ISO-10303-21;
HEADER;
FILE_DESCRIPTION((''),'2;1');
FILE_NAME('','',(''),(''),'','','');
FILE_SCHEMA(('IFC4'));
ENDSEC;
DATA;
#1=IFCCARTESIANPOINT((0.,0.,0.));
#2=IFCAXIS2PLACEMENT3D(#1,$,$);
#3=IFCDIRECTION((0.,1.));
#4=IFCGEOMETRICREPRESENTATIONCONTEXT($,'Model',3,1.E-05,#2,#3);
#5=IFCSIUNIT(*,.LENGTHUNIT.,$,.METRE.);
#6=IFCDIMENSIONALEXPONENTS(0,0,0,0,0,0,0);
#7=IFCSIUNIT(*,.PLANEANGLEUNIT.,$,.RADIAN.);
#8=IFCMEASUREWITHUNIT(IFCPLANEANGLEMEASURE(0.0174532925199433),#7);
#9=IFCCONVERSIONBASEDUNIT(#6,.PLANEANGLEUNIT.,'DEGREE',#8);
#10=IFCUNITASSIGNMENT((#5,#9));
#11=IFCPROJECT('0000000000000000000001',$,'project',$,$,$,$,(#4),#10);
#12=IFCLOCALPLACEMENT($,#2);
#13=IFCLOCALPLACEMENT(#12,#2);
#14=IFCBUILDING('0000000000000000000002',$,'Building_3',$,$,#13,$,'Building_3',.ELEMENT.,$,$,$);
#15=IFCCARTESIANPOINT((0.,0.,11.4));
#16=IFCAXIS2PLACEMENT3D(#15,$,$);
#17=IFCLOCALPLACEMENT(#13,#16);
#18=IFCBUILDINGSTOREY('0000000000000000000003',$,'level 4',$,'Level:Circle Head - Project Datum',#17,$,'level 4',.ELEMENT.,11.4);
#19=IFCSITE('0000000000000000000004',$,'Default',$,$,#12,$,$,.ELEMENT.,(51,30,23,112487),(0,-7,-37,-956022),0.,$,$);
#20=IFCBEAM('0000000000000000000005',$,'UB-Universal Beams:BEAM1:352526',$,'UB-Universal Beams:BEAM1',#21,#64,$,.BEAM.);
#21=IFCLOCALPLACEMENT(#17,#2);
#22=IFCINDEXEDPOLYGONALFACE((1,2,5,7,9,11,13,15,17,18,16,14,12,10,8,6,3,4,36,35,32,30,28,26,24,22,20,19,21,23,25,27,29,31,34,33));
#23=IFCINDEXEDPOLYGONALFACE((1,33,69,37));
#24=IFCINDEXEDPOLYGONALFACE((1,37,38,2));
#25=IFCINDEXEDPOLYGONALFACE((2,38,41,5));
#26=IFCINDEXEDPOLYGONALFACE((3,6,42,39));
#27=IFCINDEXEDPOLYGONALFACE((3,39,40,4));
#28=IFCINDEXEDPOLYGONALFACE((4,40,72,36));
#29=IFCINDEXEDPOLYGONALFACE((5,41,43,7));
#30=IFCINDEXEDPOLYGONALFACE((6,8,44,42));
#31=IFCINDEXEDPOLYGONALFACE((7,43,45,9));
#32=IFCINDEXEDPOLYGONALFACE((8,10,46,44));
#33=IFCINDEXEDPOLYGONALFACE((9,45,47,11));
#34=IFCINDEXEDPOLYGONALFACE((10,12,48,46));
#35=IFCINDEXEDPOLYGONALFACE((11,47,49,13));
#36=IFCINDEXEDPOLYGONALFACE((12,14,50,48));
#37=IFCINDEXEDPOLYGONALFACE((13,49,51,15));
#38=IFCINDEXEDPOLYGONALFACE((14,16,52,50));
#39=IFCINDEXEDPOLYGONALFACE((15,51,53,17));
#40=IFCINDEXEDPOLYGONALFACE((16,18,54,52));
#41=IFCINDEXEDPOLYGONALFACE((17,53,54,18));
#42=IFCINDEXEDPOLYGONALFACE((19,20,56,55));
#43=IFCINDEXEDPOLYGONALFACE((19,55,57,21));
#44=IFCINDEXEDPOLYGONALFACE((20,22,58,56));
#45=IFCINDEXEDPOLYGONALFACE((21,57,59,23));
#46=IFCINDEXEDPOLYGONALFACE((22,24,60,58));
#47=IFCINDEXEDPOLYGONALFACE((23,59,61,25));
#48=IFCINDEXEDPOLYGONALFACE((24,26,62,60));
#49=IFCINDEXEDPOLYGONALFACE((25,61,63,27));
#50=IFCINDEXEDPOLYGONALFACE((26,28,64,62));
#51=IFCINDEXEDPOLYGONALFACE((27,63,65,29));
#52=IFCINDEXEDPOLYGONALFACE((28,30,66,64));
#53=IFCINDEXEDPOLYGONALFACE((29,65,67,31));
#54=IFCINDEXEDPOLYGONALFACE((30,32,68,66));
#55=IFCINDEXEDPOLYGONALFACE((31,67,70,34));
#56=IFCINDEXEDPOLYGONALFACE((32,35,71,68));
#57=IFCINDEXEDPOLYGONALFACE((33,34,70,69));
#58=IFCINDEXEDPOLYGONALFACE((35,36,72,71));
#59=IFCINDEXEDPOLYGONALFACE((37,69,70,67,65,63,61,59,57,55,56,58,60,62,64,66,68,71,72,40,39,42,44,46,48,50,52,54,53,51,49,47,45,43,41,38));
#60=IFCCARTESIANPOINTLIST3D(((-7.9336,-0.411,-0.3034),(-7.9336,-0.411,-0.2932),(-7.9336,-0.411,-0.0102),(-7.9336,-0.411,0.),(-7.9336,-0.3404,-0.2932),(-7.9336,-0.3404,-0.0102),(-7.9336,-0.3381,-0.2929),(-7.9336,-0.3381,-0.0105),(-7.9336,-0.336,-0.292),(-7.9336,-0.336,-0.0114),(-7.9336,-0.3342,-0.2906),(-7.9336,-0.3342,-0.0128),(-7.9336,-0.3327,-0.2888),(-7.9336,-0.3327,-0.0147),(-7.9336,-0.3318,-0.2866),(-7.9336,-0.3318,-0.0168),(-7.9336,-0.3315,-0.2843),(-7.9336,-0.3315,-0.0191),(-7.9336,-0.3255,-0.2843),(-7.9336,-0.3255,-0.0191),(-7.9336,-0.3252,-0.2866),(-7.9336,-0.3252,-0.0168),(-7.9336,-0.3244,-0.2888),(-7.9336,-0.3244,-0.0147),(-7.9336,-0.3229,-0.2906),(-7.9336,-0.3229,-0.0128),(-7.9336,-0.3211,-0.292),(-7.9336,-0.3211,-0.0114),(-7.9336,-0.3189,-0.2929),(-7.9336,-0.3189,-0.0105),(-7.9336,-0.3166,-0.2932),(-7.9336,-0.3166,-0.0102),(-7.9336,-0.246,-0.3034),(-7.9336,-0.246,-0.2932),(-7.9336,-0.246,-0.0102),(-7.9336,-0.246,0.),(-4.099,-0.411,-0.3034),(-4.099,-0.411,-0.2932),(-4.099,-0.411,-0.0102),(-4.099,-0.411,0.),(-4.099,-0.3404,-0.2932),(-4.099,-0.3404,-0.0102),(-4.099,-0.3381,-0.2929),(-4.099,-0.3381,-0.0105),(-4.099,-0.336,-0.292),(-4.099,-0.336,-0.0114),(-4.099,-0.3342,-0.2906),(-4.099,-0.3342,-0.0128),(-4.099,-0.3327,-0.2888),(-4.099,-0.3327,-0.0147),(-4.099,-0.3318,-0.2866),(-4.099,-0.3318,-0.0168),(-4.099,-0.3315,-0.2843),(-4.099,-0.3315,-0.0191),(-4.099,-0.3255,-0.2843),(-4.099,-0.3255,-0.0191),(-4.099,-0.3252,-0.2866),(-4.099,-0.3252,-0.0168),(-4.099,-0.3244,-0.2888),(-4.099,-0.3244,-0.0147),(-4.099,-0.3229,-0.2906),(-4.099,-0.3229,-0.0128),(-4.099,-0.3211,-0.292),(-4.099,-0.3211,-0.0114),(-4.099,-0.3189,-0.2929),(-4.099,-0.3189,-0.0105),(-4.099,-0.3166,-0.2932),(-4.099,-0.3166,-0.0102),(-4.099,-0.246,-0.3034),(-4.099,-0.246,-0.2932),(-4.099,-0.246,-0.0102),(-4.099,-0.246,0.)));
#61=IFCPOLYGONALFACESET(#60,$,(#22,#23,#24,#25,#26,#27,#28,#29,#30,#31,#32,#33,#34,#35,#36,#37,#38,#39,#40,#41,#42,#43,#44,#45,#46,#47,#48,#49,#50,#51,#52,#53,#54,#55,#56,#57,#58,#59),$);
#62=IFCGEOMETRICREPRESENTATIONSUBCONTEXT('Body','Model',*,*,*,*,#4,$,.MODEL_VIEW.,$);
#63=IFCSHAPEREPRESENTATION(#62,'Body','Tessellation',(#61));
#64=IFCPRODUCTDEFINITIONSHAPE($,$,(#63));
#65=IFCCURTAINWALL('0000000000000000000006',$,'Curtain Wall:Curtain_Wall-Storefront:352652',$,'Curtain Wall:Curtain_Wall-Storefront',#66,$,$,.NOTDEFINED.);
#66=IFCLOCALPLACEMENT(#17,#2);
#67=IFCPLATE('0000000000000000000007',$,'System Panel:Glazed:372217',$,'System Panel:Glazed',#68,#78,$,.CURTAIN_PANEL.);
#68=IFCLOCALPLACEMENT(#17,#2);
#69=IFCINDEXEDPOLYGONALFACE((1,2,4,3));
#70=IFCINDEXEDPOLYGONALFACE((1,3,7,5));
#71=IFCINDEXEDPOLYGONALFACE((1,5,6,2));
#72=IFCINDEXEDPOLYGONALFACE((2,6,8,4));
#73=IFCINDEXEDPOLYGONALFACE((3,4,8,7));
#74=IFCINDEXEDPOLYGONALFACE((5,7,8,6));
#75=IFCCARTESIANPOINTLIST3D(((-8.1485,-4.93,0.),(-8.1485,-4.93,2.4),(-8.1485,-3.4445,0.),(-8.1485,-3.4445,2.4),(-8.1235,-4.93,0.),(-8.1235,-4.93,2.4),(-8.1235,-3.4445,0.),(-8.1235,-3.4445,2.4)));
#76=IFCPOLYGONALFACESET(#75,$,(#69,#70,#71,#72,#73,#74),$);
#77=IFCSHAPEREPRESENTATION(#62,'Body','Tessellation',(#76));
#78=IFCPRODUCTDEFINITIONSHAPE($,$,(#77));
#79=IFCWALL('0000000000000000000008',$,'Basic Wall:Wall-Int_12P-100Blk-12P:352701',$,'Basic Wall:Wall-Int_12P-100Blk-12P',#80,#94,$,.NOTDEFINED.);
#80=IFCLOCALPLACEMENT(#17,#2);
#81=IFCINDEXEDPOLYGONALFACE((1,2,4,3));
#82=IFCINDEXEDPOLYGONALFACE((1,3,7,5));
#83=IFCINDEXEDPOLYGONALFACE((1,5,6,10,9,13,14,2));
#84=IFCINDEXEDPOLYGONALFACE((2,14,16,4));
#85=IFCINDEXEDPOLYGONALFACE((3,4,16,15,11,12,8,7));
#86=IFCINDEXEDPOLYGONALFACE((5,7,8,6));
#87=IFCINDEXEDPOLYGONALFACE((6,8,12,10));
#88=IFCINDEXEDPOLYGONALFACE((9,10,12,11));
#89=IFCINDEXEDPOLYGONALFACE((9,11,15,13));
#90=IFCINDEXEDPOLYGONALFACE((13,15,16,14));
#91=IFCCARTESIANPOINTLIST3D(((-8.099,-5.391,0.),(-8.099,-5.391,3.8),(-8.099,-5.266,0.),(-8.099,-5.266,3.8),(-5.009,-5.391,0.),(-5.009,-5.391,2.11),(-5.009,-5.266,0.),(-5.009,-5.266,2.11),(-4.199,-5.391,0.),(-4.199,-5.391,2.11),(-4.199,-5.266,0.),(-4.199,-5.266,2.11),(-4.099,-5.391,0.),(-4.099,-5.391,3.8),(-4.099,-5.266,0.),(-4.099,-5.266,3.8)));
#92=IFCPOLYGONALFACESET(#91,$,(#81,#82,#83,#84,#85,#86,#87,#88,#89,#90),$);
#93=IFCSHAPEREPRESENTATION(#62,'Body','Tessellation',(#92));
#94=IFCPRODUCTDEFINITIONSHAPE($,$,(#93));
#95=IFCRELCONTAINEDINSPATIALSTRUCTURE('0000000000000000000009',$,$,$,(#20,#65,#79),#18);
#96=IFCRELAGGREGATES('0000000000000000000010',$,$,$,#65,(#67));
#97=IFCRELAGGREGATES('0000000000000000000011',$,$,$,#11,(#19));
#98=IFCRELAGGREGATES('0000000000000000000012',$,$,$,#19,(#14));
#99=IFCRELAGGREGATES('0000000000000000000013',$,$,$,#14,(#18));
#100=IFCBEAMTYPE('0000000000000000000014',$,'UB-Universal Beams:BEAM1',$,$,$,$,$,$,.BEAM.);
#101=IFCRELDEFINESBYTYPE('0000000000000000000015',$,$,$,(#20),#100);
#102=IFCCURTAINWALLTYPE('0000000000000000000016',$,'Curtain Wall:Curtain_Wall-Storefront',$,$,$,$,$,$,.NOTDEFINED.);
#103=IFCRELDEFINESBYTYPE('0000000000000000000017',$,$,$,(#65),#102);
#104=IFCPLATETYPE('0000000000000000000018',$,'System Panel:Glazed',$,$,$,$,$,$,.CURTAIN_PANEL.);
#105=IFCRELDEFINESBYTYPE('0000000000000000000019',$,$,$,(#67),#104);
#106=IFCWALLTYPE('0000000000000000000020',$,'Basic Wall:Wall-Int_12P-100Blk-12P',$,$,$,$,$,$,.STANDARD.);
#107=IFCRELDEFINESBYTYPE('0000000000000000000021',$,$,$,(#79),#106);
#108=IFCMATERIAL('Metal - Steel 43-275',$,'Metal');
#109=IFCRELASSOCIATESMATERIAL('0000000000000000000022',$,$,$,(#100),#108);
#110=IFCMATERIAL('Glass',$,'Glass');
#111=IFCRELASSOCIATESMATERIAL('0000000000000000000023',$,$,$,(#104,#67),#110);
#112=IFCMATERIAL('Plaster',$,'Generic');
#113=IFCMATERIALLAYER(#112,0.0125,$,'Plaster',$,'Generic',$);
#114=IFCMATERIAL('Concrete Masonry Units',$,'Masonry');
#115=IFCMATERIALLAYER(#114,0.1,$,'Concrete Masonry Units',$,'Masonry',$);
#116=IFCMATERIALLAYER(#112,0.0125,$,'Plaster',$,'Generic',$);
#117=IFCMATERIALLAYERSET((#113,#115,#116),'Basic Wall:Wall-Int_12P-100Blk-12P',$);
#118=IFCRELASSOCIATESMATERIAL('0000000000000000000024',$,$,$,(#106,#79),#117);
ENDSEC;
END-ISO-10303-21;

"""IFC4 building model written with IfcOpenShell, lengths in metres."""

from ifc_helpers import new_model, entity, si_unit, converted_unit, direction, frame, frame_2d, origin, origin_2d_with_axis, place, context, subcontext, project, spatial, polyline, circle_curve, parameter, trimmed, segment, composite_curve, rectangle, outline, extrude, source, transform, mapped, material, layer, layer_set, layer_usage, material_profile, profile_set, type_object, type_shapes, element, aggregate, save


model = new_model("IFC4")

# Units and contexts
model_context = context("Model", 3, precision=1e-05, world=origin(), true_north=direction((0.0, 1.0)))
body_context = subcontext(model_context, "Body", "Model", "MODEL_VIEW")
ifc_project = project(units=[si_unit("LENGTHUNIT", "METRE"), converted_unit("PLANEANGLEUNIT", "DEGREE", entity("IfcPlaneAngleMeasure", 0.0174532925199433), si_unit("PLANEANGLEUNIT", "RADIAN"), dimensions=[0, 0, 0, 0, 0, 0, 0])], contexts=[model_context])

# Site, building, storey
site_placement = place(None, origin())
site = spatial("IfcSite", under=ifc_project, at=site_placement, Name="Default", CompositionType="ELEMENT", RefLatitude=(51, 30, 23, 112487), RefLongitude=(0, -7, -37, -956022), RefElevation=0.0)
building_placement = place(site_placement, origin())
building = spatial("IfcBuilding", under=site, at=building_placement, Name="Building_3", LongName="Building_3", CompositionType="ELEMENT")
storey_placement = place(building_placement, frame((0.0, 0.0, 11.4)))
storey = spatial("IfcBuildingStorey", under=building, at=storey_placement, Name="level 4", ObjectType="Level:Circle Head - Project Datum", LongName="level 4", CompositionType="ELEMENT", Elevation=11.4)

# Shared definitions
ifc_material_1 = material(Name="Metal - Steel 43-275", Category="Metal")

# Beam
ifc_material_profile_1 = material_profile(ifc_material_1, outline(composite_curve([segment(polyline([(-0.0825, -0.1415), (-0.0825, -0.1517)]), True, "CONTINUOUS"), segment(polyline([(-0.0825, -0.1517), (0.0825, -0.1517)]), True, "CONTINUOUS"), segment(polyline([(0.0825, -0.1517), (0.0825, -0.1415)]), True, "CONTINUOUS"), segment(polyline([(0.0825, -0.1415), (0.0119, -0.1415)]), True, "CONTINUOUS"), segment(trimmed(circle_curve(frame_2d((0.0119, -0.1326), x_axis=(1.0, 0.0)), 0.0089), [parameter(180.0)], [parameter(270.0)], True, "PARAMETER"), False, "CONTINUOUS"), segment(polyline([(0.003, -0.1326), (0.003, 0.1326)]), True, "CONTINUOUS"), segment(trimmed(circle_curve(frame_2d((0.0119, 0.1326), x_axis=(1.0, 0.0)), 0.0089), [parameter(90.0)], [parameter(180.0)], True, "PARAMETER"), False, "CONTINUOUS"), segment(polyline([(0.0119, 0.1415), (0.0825, 0.1415)]), True, "CONTINUOUS"), segment(polyline([(0.0825, 0.1415), (0.0825, 0.1517)]), True, "CONTINUOUS"), segment(polyline([(0.0825, 0.1517), (-0.0825, 0.1517)]), True, "CONTINUOUS"), segment(polyline([(-0.0825, 0.1517), (-0.0825, 0.1415)]), True, "CONTINUOUS"), segment(polyline([(-0.0825, 0.1415), (-0.0119, 0.1415)]), True, "CONTINUOUS"), segment(trimmed(circle_curve(frame_2d((-0.0119, 0.1326), x_axis=(1.0, 0.0)), 0.0089), [parameter(360.0)], [parameter(90.0)], True, "PARAMETER"), False, "CONTINUOUS"), segment(polyline([(-0.003, 0.1326), (-0.003, -0.1326)]), True, "CONTINUOUS"), segment(trimmed(circle_curve(frame_2d((-0.0119, -0.1326), x_axis=(1.0, 0.0)), 0.0089), [parameter(270.0)], [parameter(360.0)], True, "PARAMETER"), False, "CONTINUOUS"), segment(polyline([(-0.0119, -0.1415), (-0.0825, -0.1415)]), True, "CONTINUOUS")], self_intersect=False)), Name="BEAM1")
ifc_profile_set_1 = profile_set([ifc_material_profile_1], Name="BEAM1")
beam_type_1 = type_object("IfcBeamType", Name="UB-Universal Beams:BEAM1", PredefinedType="BEAM", material=ifc_profile_set_1)
shared_shape_1 = source(origin(), body_context, "Body", "SweptSolid", [
    extrude(outline(composite_curve([segment(polyline([(-0.0825, -0.1415), (-0.0825, -0.1517)]), True, "CONTINUOUS"), segment(polyline([(-0.0825, -0.1517), (0.0825, -0.1517)]), True, "CONTINUOUS"), segment(polyline([(0.0825, -0.1517), (0.0825, -0.1415)]), True, "CONTINUOUS"), segment(polyline([(0.0825, -0.1415), (0.0119, -0.1415)]), True, "CONTINUOUS"), segment(trimmed(circle_curve(frame_2d((0.0119, -0.1326), x_axis=(1.0, 0.0)), 0.0089), [parameter(180.0)], [parameter(270.0)], True, "PARAMETER"), False, "CONTINUOUS"), segment(polyline([(0.003, -0.1326), (0.003, 0.1326)]), True, "CONTINUOUS"), segment(trimmed(circle_curve(frame_2d((0.0119, 0.1326), x_axis=(1.0, 0.0)), 0.0089), [parameter(90.0)], [parameter(180.0)], True, "PARAMETER"), False, "CONTINUOUS"), segment(polyline([(0.0119, 0.1415), (0.0825, 0.1415)]), True, "CONTINUOUS"), segment(polyline([(0.0825, 0.1415), (0.0825, 0.1517)]), True, "CONTINUOUS"), segment(polyline([(0.0825, 0.1517), (-0.0825, 0.1517)]), True, "CONTINUOUS"), segment(polyline([(-0.0825, 0.1517), (-0.0825, 0.1415)]), True, "CONTINUOUS"), segment(polyline([(-0.0825, 0.1415), (-0.0119, 0.1415)]), True, "CONTINUOUS"), segment(trimmed(circle_curve(frame_2d((-0.0119, 0.1326), x_axis=(1.0, 0.0)), 0.0089), [parameter(360.0)], [parameter(90.0)], True, "PARAMETER"), False, "CONTINUOUS"), segment(polyline([(-0.003, 0.1326), (-0.003, -0.1326)]), True, "CONTINUOUS"), segment(trimmed(circle_curve(frame_2d((-0.0119, -0.1326), x_axis=(1.0, 0.0)), 0.0089), [parameter(270.0)], [parameter(360.0)], True, "PARAMETER"), False, "CONTINUOUS"), segment(polyline([(-0.0119, -0.1415), (-0.0825, -0.1415)]), True, "CONTINUOUS")], self_intersect=False)), frame((-2.0, 0.0, 0.0), z_axis=(-1.0, 0.0, 0.0), x_axis=(0.0, -1.0, 0.0)), (0.0, 0.0, -1.0), 3.8346),
])
type_shapes(beam_type_1, [shared_shape_1])
beam_1_placement = place(storey_placement, frame((-6.099, -0.3285, -0.1517), z_axis=(0.0, 0.0, 1.0), x_axis=(-1.0, 0.0, 0.0)))
element("IfcBeam", 1, at=beam_1_placement, inside=storey, type_object=beam_type_1, Name="UB-Universal Beams:BEAM1:352526", ObjectType="UB-Universal Beams:BEAM1", PredefinedType="BEAM", context=body_context, shape_type="MappedRepresentation", body=[
    mapped(shared_shape_1, transform((0.0, 0.0, 0.0), scale=1.0)),
])

# Curtain wall, plate
curtain_wall_type = type_object("IfcCurtainWallType", Name="Curtain Wall:Curtain_Wall-Storefront", PredefinedType="NOTDEFINED")
curtain_wall_placement = place(storey_placement, frame((0.0, 0.0, -11.4)))
curtain_wall = element("IfcCurtainWall", 2, at=curtain_wall_placement, inside=storey, type_object=curtain_wall_type, Name="Curtain Wall:Curtain_Wall-Storefront:352652", ObjectType="Curtain Wall:Curtain_Wall-Storefront", PredefinedType="NOTDEFINED")
ifc_material_2 = material(Name="Glass", Category="Glass")
plate_type = type_object("IfcPlateType", Name="System Panel:Glazed", PredefinedType="CURTAIN_PANEL", material=ifc_material_2)
shared_shape_2 = source(origin(), body_context, "Body", "SweptSolid", [
    extrude(rectangle(XDim=0.025, YDim=1.4855, at=origin_2d_with_axis()), frame((0.7428, 0.0125, 0.0), z_axis=(0.0, 0.0, 1.0), x_axis=(0.0, 1.0, 0.0)), (0.0, 0.0, 1.0), 2.4),
])
type_shapes(plate_type, [shared_shape_2])
plate_placement = place(curtain_wall_placement, frame((-8.1235, -4.93, 11.4), z_axis=(0.0, 0.0, 1.0), x_axis=(0.0, 1.0, 0.0)))
plate = element("IfcPlate", 3, at=plate_placement, type_object=plate_type, material=ifc_material_2, Name="System Panel:Glazed:372217", ObjectType="System Panel:Glazed", PredefinedType="CURTAIN_PANEL", context=body_context, shape_type="MappedRepresentation", body=[
    mapped(shared_shape_2, transform((0.0, 0.0, 0.0), scale=1.0)),
])
aggregate(curtain_wall, [plate])

# Wall, opening
ifc_material_3 = material(Name="Plaster", Category="Generic")
ifc_layer_1 = layer(ifc_material_3, 0.0125, Name="Plaster", Category="Generic")
ifc_material_4 = material(Name="Concrete Masonry Units", Category="Masonry")
ifc_layer_2 = layer(ifc_material_4, 0.1, Name="Concrete Masonry Units", Category="Masonry")
ifc_layer_3 = layer(ifc_material_3, 0.0125, Name="Plaster", Category="Generic")
ifc_layer_set = layer_set([ifc_layer_1, ifc_layer_2, ifc_layer_3], Name="Basic Wall:Wall-Int_12P-100Blk-12P")
ifc_layer_usage = layer_usage(ifc_layer_set, "AXIS2", "NEGATIVE", 0.0625)
wall_type = type_object("IfcWallType", Name="Basic Wall:Wall-Int_12P-100Blk-12P", PredefinedType="STANDARD", material=ifc_layer_set)
wall_placement = place(storey_placement, frame((-8.099, -5.3285, 0.0)))
wall = element("IfcWall", 4, at=wall_placement, inside=storey, type_object=wall_type, material=ifc_layer_usage, Name="Basic Wall:Wall-Int_12P-100Blk-12P:352701", ObjectType="Basic Wall:Wall-Int_12P-100Blk-12P", PredefinedType="NOTDEFINED", context=body_context, shape_type="SweptSolid", body=[
    extrude(rectangle(XDim=4.0, YDim=0.125, at=frame_2d((2.0, 0.0), x_axis=(-1.0, 0.0))), origin(), (0.0, 0.0, 1.0), 3.8),
])
opening_placement = place(wall_placement, frame((3.9, 0.0625, 0.0)))
element("IfcOpeningElement", 5, at=opening_placement, cuts=wall, PredefinedType="OPENING", context=body_context, shape_type="SweptSolid", body=[
    extrude(rectangle(XDim=2.11, YDim=0.81, at=frame_2d((1.055, 0.405), x_axis=(1.0, 0.0))), frame((0.0, 0.0, 0.0), z_axis=(0.0, -1.0, 0.0), x_axis=(0.0, 0.0, 1.0)), (0.0, 0.0, 1.0), 0.125),
])

save(model, "model.ifc")
